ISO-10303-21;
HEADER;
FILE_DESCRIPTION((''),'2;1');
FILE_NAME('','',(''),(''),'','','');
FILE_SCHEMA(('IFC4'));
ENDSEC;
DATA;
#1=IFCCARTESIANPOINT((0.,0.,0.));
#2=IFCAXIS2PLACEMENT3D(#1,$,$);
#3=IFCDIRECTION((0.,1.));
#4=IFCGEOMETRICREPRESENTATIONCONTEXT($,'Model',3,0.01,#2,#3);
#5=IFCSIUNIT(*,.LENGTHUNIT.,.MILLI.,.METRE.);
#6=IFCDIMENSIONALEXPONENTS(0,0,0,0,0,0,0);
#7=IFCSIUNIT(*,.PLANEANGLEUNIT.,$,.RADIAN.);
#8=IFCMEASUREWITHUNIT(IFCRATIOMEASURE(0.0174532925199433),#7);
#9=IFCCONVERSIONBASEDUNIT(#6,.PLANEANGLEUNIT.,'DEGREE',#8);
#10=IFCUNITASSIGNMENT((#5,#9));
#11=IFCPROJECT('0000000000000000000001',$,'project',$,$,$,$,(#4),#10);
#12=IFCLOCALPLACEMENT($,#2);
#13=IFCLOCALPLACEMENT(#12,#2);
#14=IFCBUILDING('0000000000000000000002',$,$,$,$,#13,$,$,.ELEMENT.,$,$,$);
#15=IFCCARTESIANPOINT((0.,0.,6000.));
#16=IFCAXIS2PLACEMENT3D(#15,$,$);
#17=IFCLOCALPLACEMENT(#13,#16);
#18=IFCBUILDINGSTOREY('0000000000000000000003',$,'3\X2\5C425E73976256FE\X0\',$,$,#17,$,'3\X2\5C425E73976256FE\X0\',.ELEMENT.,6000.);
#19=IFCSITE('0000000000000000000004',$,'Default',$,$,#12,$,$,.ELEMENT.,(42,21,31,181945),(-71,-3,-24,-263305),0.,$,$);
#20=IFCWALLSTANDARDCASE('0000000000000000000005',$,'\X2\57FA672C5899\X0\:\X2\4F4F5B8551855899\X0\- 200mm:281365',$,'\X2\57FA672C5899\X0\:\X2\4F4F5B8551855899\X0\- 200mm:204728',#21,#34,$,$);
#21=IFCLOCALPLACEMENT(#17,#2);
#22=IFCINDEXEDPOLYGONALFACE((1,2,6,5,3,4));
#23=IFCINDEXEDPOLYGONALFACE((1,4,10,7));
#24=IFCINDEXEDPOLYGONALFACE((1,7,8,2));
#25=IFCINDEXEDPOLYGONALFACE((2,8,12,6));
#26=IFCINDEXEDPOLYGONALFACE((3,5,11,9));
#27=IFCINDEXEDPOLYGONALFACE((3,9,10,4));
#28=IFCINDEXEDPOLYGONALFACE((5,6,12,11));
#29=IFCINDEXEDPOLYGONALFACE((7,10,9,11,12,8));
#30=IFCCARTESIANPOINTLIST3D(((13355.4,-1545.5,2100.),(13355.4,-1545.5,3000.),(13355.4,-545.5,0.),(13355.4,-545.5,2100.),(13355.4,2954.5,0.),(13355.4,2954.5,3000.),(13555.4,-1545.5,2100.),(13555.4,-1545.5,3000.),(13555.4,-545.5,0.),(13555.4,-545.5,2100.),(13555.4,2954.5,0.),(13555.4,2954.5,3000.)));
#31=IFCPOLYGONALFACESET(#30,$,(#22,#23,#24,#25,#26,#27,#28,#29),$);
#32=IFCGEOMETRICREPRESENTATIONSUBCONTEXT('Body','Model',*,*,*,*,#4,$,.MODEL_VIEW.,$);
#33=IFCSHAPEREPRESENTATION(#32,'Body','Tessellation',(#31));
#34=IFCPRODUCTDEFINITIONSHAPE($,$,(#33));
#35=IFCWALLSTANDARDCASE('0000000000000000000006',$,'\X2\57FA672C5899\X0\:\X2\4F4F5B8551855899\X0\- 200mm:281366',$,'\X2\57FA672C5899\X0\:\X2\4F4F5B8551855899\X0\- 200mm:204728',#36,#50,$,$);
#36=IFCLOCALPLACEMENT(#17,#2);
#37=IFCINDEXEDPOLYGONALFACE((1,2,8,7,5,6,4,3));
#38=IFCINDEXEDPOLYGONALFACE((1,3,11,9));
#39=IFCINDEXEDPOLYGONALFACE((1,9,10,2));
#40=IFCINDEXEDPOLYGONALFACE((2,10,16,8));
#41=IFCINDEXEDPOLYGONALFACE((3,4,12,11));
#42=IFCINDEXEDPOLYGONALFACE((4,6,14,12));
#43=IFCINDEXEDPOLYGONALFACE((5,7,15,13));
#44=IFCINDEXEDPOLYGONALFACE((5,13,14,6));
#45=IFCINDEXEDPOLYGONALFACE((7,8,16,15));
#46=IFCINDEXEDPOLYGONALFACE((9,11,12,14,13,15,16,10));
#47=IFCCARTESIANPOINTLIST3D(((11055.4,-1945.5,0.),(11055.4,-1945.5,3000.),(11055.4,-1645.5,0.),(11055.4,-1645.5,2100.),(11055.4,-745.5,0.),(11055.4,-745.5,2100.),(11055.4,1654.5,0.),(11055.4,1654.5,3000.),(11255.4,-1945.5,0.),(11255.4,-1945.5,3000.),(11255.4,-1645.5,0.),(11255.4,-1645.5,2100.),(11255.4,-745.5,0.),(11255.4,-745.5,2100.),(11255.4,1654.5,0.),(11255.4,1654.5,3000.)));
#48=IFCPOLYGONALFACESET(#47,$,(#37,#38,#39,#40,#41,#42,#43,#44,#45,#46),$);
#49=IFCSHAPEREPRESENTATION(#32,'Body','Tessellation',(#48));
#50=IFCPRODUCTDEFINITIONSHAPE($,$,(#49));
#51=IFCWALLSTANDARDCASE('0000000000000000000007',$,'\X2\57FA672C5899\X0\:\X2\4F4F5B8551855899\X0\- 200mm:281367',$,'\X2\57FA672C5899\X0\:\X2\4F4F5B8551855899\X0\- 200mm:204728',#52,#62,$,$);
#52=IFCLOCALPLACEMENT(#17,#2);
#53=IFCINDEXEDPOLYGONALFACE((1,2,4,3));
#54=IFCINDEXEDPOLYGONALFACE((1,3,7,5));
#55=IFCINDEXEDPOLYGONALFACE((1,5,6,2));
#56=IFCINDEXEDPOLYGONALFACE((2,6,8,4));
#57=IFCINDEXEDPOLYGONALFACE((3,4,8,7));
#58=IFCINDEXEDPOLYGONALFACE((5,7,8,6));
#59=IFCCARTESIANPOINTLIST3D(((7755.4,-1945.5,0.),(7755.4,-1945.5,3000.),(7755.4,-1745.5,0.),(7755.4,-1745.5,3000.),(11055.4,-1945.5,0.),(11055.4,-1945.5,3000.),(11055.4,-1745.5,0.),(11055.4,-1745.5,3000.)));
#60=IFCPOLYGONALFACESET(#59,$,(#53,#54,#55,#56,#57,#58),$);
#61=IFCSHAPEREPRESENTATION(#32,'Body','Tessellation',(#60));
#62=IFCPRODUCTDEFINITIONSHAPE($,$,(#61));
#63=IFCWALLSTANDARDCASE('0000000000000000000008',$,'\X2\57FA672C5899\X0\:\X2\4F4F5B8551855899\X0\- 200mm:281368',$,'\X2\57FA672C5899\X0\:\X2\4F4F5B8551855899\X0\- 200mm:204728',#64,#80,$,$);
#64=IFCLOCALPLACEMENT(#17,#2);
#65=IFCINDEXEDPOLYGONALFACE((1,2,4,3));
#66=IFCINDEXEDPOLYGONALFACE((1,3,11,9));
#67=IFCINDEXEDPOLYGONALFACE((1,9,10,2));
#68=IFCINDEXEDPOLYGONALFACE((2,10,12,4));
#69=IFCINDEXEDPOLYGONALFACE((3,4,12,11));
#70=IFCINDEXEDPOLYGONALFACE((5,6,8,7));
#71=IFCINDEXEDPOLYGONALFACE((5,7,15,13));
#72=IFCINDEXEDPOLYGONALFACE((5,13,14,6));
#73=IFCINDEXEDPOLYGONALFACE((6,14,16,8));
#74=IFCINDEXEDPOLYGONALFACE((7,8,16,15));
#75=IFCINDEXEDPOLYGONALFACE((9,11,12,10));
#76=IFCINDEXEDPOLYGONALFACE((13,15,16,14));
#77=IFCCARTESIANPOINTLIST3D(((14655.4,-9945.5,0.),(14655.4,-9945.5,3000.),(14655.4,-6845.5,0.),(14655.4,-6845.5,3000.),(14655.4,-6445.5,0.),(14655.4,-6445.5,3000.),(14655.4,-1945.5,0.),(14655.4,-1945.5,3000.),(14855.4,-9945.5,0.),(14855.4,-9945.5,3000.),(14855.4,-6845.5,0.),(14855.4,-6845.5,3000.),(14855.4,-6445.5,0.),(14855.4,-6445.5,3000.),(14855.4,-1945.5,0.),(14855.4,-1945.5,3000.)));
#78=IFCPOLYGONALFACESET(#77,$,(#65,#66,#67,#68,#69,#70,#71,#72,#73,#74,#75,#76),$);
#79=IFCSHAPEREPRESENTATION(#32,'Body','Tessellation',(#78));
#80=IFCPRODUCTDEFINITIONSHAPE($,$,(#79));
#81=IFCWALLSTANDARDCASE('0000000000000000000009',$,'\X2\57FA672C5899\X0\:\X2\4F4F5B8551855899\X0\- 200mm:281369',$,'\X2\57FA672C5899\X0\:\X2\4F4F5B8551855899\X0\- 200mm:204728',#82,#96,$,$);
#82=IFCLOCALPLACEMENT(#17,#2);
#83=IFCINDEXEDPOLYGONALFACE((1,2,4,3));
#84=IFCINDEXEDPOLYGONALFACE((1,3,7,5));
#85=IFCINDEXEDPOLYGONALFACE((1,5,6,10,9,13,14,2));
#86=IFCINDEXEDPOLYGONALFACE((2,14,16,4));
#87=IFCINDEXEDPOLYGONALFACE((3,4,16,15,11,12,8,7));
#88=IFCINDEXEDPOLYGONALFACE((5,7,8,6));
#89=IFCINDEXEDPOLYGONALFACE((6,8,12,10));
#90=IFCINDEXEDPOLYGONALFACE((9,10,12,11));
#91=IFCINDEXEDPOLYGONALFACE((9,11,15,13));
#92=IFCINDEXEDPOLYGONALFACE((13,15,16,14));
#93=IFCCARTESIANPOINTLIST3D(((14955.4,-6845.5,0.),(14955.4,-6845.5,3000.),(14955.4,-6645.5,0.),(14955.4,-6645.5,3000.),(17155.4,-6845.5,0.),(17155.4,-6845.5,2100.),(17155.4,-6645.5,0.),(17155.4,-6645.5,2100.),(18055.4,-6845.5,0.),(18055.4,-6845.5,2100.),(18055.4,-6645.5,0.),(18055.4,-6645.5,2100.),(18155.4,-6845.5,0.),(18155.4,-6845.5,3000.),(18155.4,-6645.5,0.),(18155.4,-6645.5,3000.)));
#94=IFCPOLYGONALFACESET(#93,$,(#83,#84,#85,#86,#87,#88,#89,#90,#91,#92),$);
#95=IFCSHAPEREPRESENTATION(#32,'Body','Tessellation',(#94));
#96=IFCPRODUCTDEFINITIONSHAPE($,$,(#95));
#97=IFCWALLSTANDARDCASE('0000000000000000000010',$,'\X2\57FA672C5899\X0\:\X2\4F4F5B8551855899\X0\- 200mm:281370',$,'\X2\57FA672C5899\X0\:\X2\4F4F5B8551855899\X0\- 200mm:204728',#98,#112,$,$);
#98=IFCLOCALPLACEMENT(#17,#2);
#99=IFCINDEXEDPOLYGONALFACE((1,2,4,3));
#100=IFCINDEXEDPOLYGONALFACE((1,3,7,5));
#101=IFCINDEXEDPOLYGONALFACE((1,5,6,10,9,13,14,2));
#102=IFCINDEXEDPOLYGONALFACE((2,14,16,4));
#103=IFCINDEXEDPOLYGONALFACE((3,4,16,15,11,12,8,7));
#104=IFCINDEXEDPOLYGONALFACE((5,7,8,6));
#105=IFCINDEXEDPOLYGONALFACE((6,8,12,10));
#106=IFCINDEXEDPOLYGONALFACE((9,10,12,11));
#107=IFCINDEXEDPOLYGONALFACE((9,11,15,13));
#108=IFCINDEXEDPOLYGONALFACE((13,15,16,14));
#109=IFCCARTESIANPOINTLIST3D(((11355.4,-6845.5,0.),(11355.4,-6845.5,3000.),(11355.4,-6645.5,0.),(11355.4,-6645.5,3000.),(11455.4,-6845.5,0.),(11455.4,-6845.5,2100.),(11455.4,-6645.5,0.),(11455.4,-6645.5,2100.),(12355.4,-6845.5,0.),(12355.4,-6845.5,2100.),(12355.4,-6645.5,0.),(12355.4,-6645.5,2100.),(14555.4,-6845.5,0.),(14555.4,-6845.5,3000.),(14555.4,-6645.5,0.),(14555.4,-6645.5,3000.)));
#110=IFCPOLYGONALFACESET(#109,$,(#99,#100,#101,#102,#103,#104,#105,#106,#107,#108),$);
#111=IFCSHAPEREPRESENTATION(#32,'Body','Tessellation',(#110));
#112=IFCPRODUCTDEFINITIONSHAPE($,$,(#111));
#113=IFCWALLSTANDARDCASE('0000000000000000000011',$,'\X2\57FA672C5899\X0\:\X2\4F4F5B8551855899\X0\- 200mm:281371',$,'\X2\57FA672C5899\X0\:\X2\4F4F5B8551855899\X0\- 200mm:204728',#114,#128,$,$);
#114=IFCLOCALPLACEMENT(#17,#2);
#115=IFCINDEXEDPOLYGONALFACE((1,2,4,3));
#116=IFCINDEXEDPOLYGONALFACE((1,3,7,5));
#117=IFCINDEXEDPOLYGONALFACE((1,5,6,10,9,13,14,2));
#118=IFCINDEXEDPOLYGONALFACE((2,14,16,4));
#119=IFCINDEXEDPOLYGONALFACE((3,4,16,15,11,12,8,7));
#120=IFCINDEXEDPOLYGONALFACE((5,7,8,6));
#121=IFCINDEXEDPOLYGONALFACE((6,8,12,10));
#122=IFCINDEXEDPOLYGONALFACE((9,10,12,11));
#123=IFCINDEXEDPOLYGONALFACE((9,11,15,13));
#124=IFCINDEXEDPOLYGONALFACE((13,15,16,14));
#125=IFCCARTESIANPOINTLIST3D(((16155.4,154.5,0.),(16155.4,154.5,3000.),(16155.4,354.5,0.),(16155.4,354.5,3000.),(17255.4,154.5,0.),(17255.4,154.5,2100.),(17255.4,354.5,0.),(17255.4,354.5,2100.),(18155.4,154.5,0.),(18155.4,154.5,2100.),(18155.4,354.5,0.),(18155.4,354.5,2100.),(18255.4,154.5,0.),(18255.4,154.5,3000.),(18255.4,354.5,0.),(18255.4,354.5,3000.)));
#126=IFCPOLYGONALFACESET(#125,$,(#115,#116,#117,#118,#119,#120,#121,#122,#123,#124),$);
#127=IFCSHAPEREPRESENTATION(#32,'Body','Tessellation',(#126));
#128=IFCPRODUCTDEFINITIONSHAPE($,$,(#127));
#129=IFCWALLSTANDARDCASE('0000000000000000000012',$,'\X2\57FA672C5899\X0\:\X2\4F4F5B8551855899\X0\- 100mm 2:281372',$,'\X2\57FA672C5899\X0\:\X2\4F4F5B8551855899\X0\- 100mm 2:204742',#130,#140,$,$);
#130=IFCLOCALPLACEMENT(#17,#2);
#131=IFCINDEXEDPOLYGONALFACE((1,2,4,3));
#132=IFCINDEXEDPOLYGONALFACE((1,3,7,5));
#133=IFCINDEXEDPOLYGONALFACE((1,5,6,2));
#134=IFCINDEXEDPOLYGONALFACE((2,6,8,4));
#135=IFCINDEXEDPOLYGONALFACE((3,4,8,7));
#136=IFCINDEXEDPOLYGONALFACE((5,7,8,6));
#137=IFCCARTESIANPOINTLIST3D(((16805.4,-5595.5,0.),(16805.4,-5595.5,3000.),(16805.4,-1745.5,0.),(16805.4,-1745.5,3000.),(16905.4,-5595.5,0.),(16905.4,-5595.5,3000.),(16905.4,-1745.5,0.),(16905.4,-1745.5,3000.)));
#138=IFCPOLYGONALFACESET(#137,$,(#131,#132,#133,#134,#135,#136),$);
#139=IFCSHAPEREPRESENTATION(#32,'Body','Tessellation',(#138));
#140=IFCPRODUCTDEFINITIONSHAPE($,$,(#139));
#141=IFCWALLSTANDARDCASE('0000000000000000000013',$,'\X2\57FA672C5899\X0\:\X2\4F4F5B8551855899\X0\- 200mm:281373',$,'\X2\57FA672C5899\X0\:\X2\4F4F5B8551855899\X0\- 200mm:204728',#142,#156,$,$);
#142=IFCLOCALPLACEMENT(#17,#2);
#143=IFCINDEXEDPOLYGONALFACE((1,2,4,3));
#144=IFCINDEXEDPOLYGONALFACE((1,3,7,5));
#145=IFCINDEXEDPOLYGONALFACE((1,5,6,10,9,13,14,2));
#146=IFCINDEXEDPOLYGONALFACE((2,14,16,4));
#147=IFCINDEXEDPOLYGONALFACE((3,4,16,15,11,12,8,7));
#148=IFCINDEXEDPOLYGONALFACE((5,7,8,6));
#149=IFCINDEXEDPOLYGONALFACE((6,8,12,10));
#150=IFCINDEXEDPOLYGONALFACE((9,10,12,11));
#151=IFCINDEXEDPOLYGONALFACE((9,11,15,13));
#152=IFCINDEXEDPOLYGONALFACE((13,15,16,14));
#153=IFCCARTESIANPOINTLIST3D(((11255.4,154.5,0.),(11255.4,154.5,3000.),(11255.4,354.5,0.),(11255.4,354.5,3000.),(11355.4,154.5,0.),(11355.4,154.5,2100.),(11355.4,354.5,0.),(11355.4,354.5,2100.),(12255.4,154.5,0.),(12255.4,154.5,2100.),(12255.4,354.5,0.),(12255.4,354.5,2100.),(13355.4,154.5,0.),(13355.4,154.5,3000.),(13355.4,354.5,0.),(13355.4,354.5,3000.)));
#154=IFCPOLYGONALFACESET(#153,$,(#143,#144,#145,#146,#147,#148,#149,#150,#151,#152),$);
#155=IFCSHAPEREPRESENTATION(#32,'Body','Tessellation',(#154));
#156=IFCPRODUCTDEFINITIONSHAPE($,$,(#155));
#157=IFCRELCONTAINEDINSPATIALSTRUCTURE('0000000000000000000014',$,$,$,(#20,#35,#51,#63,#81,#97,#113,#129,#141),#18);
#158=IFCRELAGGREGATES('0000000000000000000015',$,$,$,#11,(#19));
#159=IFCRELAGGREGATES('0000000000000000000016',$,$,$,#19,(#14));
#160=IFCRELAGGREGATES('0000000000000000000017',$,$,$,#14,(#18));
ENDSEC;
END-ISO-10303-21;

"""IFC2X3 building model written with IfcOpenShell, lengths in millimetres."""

from ifc_helpers import new_model, entity, si_unit, converted_unit, direction, frame, frame_2d, origin, place, context, subcontext, project, spatial, polyline, rectangle, extrude, clip, bounded_halfspace, element, save


model = new_model("IFC2X3")

# Units and contexts
model_context = context("Model", 3, precision=0.01, world=origin(), true_north=direction((0.0, 1.0)))
body_context = subcontext(model_context, "Body", "Model", "MODEL_VIEW")
ifc_project = project(units=[si_unit("LENGTHUNIT", "METRE", prefix="MILLI"), converted_unit("PLANEANGLEUNIT", "DEGREE", entity("IfcRatioMeasure", 0.0174532925199433), si_unit("PLANEANGLEUNIT", "RADIAN"), dimensions=[0, 0, 0, 0, 0, 0, 0])], contexts=[model_context])

# Site, building, storey
site_placement = place(None, origin())
site = spatial("IfcSite", under=ifc_project, at=site_placement, Name="Default", CompositionType="ELEMENT", RefLatitude=(42, 21, 31, 181945), RefLongitude=(-71, -3, -24, -263305), RefElevation=0.0)
building_placement = place(site_placement, origin())
building = spatial("IfcBuilding", under=site, at=building_placement, CompositionType="ELEMENT")
storey_placement = place(building_placement, frame((0.0, 0.0, 6000.0)))
storey = spatial("IfcBuildingStorey", under=building, at=storey_placement, Name="3层平面图", LongName="3层平面图", CompositionType="ELEMENT", Elevation=6000.0)

# Walls, openings
wall_1_placement = place(storey_placement, frame((13455.4, -1545.5, 0.0), z_axis=(0.0, 0.0, 1.0), x_axis=(0.0, 1.0, 0.0)))
wall_1 = element("IfcWallStandardCase", 1, at=wall_1_placement, inside=storey, Name="基本墙:住宅内墙- 200mm:281365", ObjectType="基本墙:住宅内墙- 200mm:204728", context=body_context, shape_type="Clipping", body=[
    clip(clip(extrude(rectangle(XDim=4500.0, YDim=200.0, at=frame_2d((2250.0, 0.0), x_axis=(-1.0, 0.0))), origin(), (0.0, 0.0, 1.0), 3000.0), bounded_halfspace(frame((0.0, -100.0, 2100.0), z_axis=(1.0, 0.0, 0.0), x_axis=(0.0, 0.0, -1.0)), True, frame((0.0, -100.0, 2100.0), z_axis=(1.0, 0.0, 0.0), x_axis=(0.0, 0.0, -1.0)), polyline([(0.0, 0.0), (0.0, 200.0), (-900.0, 200.0), (-900.0, 0.0), (0.0, 0.0)]))), bounded_halfspace(frame((4500.0, -100.0, 3000.0), z_axis=(-1.0, 0.0, 0.0), x_axis=(0.0, 0.0, -1.0)), True, frame((4500.0, -100.0, 3000.0), z_axis=(-1.0, 0.0, 0.0), x_axis=(0.0, 0.0, -1.0)), polyline([(0.0, 0.0), (0.0, -200.0), (3000.0, -200.0), (3000.0, 0.0), (0.0, 0.0)]))),
])
opening_1_placement = place(wall_1_placement, frame((1000.0, 100.0, 0.0)))
element("IfcOpeningElement", 2, at=opening_1_placement, cuts=wall_1, ObjectType="Opening", context=body_context, shape_type="SweptSolid", body=[
    extrude(rectangle(XDim=2100.0, YDim=1000.0, at=frame_2d((1050.0, 500.0), x_axis=(1.0, 0.0))), frame((0.0, 0.0, 0.0), z_axis=(0.0, -1.0, 0.0), x_axis=(0.0, 0.0, 1.0)), (0.0, 0.0, 1.0), 200.0),
])
wall_2_placement = place(storey_placement, frame((11155.4, 1654.5, 0.0), z_axis=(0.0, 0.0, 1.0), x_axis=(0.0, -1.0, 0.0)))
wall_2 = element("IfcWallStandardCase", 3, at=wall_2_placement, inside=storey, Name="基本墙:住宅内墙- 200mm:281366", ObjectType="基本墙:住宅内墙- 200mm:204728", context=body_context, shape_type="SweptSolid", body=[
    extrude(rectangle(XDim=3600.0, YDim=200.0, at=frame_2d((1800.0, 0.0), x_axis=(-1.0, 0.0))), origin(), (0.0, 0.0, 1.0), 3000.0),
])
opening_2_placement = place(wall_2_placement, frame((3300.0, 100.0, 0.0)))
element("IfcOpeningElement", 4, at=opening_2_placement, cuts=wall_2, ObjectType="Opening", context=body_context, shape_type="SweptSolid", body=[
    extrude(rectangle(XDim=2100.0, YDim=900.0, at=frame_2d((1050.0, 450.0), x_axis=(1.0, 0.0))), frame((0.0, 0.0, 0.0), z_axis=(0.0, -1.0, 0.0), x_axis=(0.0, 0.0, 1.0)), (0.0, 0.0, 1.0), 200.0),
])

# Wall
wall_3_placement = place(storey_placement, frame((11055.4, -1845.5, 0.0), z_axis=(0.0, 0.0, 1.0), x_axis=(-1.0, 0.0, 0.0)))
element("IfcWallStandardCase", 5, at=wall_3_placement, inside=storey, Name="基本墙:住宅内墙- 200mm:281367", ObjectType="基本墙:住宅内墙- 200mm:204728", context=body_context, shape_type="Clipping", body=[
    clip(extrude(rectangle(XDim=3300.0, YDim=200.0, at=frame_2d((1650.0, 0.0), x_axis=(-1.0, 0.0))), origin(), (0.0, 0.0, 1.0), 3000.0), bounded_halfspace(frame((3300.0, -100.0, 3000.0), z_axis=(1.0, 0.0, 0.0), x_axis=(0.0, 0.0, -1.0)), False, frame((3300.0, -100.0, 3000.0), z_axis=(1.0, 0.0, 0.0), x_axis=(0.0, 0.0, -1.0)), polyline([(0.0, 0.0), (3000.0, 0.0), (3000.0, 200.0), (0.0, 200.0), (0.0, 0.0)]))),
])

# Walls, openings
wall_4_placement = place(storey_placement, frame((14755.4, -1945.5, 0.0), z_axis=(0.0, 0.0, 1.0), x_axis=(0.0, -1.0, 0.0)))
wall_4 = element("IfcWallStandardCase", 6, at=wall_4_placement, inside=storey, Name="基本墙:住宅内墙- 200mm:281368", ObjectType="基本墙:住宅内墙- 200mm:204728", context=body_context, shape_type="Clipping", body=[
    clip(extrude(rectangle(XDim=8000.0, YDim=200.0, at=frame_2d((4000.0, 0.0), x_axis=(-1.0, 0.0))), origin(), (0.0, 0.0, 1.0), 3000.0), bounded_halfspace(frame((8000.0, -100.0, 3000.0), z_axis=(1.0, 0.0, 0.0), x_axis=(0.0, 0.0, -1.0)), False, frame((8000.0, -100.0, 3000.0), z_axis=(1.0, 0.0, 0.0), x_axis=(0.0, 0.0, -1.0)), polyline([(0.0, 0.0), (3000.0, 0.0), (3000.0, 200.0), (0.0, 200.0), (0.0, 0.0)]))),
])
opening_3_placement = place(storey_placement, frame((14755.4, -1945.5, 0.0), z_axis=(0.0, 0.0, 1.0), x_axis=(0.0, -1.0, 0.0)))
element("IfcOpeningElement", 7, at=opening_3_placement, cuts=wall_4, ObjectType="Opening", context=body_context, shape_type="SweptSolid", body=[
    extrude(rectangle(XDim=3000.0, YDim=200.0, at=frame_2d((0.0, 0.0), x_axis=(1.0, 0.0))), frame((4900.0, 0.0, 1500.0), z_axis=(-1.0, 0.0, 0.0), x_axis=(0.0, 0.0, 1.0)), (0.0, 0.0, 1.0), 400.0),
])
wall_5_placement = place(storey_placement, frame((18155.4, -6745.5, 0.0), z_axis=(0.0, 0.0, 1.0), x_axis=(-1.0, 0.0, 0.0)))
wall_5 = element("IfcWallStandardCase", 8, at=wall_5_placement, inside=storey, Name="基本墙:住宅内墙- 200mm:281369", ObjectType="基本墙:住宅内墙- 200mm:204728", context=body_context, shape_type="Clipping", body=[
    clip(clip(extrude(rectangle(XDim=3200.0, YDim=200.0, at=frame_2d((1600.0, 0.0), x_axis=(-1.0, 0.0))), origin(), (0.0, 0.0, 1.0), 3000.0), bounded_halfspace(frame((0.0, -100.0, 0.0), z_axis=(-1.0, 0.0, 0.0), x_axis=(0.0, 0.0, -1.0)), False, frame((0.0, -100.0, 0.0), z_axis=(-1.0, 0.0, 0.0), x_axis=(0.0, 0.0, -1.0)), polyline([(0.0, 0.0), (-3000.0, 0.0), (-3000.0, -200.0), (0.0, -200.0), (0.0, 0.0)]))), bounded_halfspace(frame((3200.0, -100.0, 3000.0), z_axis=(1.0, 0.0, 0.0), x_axis=(0.0, 0.0, -1.0)), False, frame((3200.0, -100.0, 3000.0), z_axis=(1.0, 0.0, 0.0), x_axis=(0.0, 0.0, -1.0)), polyline([(0.0, 0.0), (3000.0, 0.0), (3000.0, 200.0), (0.0, 200.0), (0.0, 0.0)]))),
])
opening_4_placement = place(wall_5_placement, frame((100.0, -100.0, 0.0)))
element("IfcOpeningElement", 9, at=opening_4_placement, cuts=wall_5, ObjectType="Opening", context=body_context, shape_type="SweptSolid", body=[
    extrude(rectangle(XDim=2100.0, YDim=900.0, at=frame_2d((1050.0, 450.0), x_axis=(1.0, 0.0))), frame((0.0, 0.0, 0.0), z_axis=(0.0, 1.0, 0.0), x_axis=(0.0, 0.0, 1.0)), (0.0, 0.0, 1.0), 200.0),
])
wall_6_placement = place(storey_placement, frame((11355.4, -6745.5, 0.0)))
wall_6 = element("IfcWallStandardCase", 10, at=wall_6_placement, inside=storey, Name="基本墙:住宅内墙- 200mm:281370", ObjectType="基本墙:住宅内墙- 200mm:204728", context=body_context, shape_type="Clipping", body=[
    clip(clip(extrude(rectangle(XDim=3200.0, YDim=200.0, at=frame_2d((1600.0, 0.0), x_axis=(-1.0, 0.0))), origin(), (0.0, 0.0, 1.0), 3000.0), bounded_halfspace(frame((0.0, -100.0, 0.0), z_axis=(1.0, 0.0, 0.0), x_axis=(0.0, 0.0, -1.0)), True, frame((0.0, -100.0, 0.0), z_axis=(1.0, 0.0, 0.0), x_axis=(0.0, 0.0, -1.0)), polyline([(0.0, 0.0), (0.0, 200.0), (-3000.0, 200.0), (-3000.0, 0.0), (0.0, 0.0)]))), bounded_halfspace(frame((3200.0, -100.0, 3000.0), z_axis=(1.0, 0.0, 0.0), x_axis=(0.0, 0.0, -1.0)), False, frame((3200.0, -100.0, 3000.0), z_axis=(1.0, 0.0, 0.0), x_axis=(0.0, 0.0, -1.0)), polyline([(0.0, 0.0), (3000.0, 0.0), (3000.0, 200.0), (0.0, 200.0), (0.0, 0.0)]))),
])
opening_5_placement = place(wall_6_placement, frame((1000.0, 100.0, 0.0)))
element("IfcOpeningElement", 11, at=opening_5_placement, cuts=wall_6, ObjectType="Opening", context=body_context, shape_type="SweptSolid", body=[
    extrude(rectangle(XDim=2100.0, YDim=900.0, at=frame_2d((1050.0, 450.0), x_axis=(1.0, 0.0))), frame((0.0, 0.0, 0.0), z_axis=(0.0, -1.0, 0.0), x_axis=(0.0, 0.0, 1.0)), (0.0, 0.0, 1.0), 200.0),
])
wall_7_placement = place(storey_placement, frame((18255.4, 254.5, 0.0), z_axis=(0.0, 0.0, 1.0), x_axis=(-1.0, 0.0, 0.0)))
wall_7 = element("IfcWallStandardCase", 12, at=wall_7_placement, inside=storey, Name="基本墙:住宅内墙- 200mm:281371", ObjectType="基本墙:住宅内墙- 200mm:204728", context=body_context, shape_type="SweptSolid", body=[
    extrude(rectangle(XDim=2100.0, YDim=200.0, at=frame_2d((1050.0, 0.0), x_axis=(-1.0, 0.0))), origin(), (0.0, 0.0, 1.0), 3000.0),
])
opening_6_placement = place(wall_7_placement, frame((1000.0, 100.0, 0.0)))
element("IfcOpeningElement", 13, at=opening_6_placement, cuts=wall_7, ObjectType="Opening", context=body_context, shape_type="SweptSolid", body=[
    extrude(rectangle(XDim=2100.0, YDim=900.0, at=frame_2d((1050.0, 450.0), x_axis=(1.0, 0.0))), frame((0.0, 0.0, 0.0), z_axis=(0.0, -1.0, 0.0), x_axis=(0.0, 0.0, 1.0)), (0.0, 0.0, 1.0), 200.0),
])

# Wall
wall_8_placement = place(storey_placement, frame((16855.4, -1745.5, 0.0), z_axis=(0.0, 0.0, 1.0), x_axis=(0.0, -1.0, 0.0)))
element("IfcWallStandardCase", 14, at=wall_8_placement, inside=storey, Name="基本墙:住宅内墙- 100mm 2:281372", ObjectType="基本墙:住宅内墙- 100mm 2:204742", context=body_context, shape_type="SweptSolid", body=[
    extrude(rectangle(XDim=3850.0, YDim=100.0, at=frame_2d((1925.0, 0.0), x_axis=(-1.0, 0.0))), origin(), (0.0, 0.0, 1.0), 3000.0),
])

# Wall, opening
wall_9_placement = place(storey_placement, frame((11255.4, 254.5, 0.0)))
wall_9 = element("IfcWallStandardCase", 15, at=wall_9_placement, inside=storey, Name="基本墙:住宅内墙- 200mm:281373", ObjectType="基本墙:住宅内墙- 200mm:204728", context=body_context, shape_type="SweptSolid", body=[
    extrude(rectangle(XDim=2100.0, YDim=200.0, at=frame_2d((1050.0, 0.0), x_axis=(-1.0, 0.0))), origin(), (0.0, 0.0, 1.0), 3000.0),
])
opening_7_placement = place(wall_9_placement, frame((100.0, -100.0, 0.0)))
element("IfcOpeningElement", 16, at=opening_7_placement, cuts=wall_9, ObjectType="Opening", context=body_context, shape_type="SweptSolid", body=[
    extrude(rectangle(XDim=2100.0, YDim=900.0, at=frame_2d((1050.0, 450.0), x_axis=(1.0, 0.0))), frame((0.0, 0.0, 0.0), z_axis=(0.0, 1.0, 0.0), x_axis=(0.0, 0.0, 1.0)), (0.0, 0.0, 1.0), 200.0),
])

save(model, "model.ifc")
